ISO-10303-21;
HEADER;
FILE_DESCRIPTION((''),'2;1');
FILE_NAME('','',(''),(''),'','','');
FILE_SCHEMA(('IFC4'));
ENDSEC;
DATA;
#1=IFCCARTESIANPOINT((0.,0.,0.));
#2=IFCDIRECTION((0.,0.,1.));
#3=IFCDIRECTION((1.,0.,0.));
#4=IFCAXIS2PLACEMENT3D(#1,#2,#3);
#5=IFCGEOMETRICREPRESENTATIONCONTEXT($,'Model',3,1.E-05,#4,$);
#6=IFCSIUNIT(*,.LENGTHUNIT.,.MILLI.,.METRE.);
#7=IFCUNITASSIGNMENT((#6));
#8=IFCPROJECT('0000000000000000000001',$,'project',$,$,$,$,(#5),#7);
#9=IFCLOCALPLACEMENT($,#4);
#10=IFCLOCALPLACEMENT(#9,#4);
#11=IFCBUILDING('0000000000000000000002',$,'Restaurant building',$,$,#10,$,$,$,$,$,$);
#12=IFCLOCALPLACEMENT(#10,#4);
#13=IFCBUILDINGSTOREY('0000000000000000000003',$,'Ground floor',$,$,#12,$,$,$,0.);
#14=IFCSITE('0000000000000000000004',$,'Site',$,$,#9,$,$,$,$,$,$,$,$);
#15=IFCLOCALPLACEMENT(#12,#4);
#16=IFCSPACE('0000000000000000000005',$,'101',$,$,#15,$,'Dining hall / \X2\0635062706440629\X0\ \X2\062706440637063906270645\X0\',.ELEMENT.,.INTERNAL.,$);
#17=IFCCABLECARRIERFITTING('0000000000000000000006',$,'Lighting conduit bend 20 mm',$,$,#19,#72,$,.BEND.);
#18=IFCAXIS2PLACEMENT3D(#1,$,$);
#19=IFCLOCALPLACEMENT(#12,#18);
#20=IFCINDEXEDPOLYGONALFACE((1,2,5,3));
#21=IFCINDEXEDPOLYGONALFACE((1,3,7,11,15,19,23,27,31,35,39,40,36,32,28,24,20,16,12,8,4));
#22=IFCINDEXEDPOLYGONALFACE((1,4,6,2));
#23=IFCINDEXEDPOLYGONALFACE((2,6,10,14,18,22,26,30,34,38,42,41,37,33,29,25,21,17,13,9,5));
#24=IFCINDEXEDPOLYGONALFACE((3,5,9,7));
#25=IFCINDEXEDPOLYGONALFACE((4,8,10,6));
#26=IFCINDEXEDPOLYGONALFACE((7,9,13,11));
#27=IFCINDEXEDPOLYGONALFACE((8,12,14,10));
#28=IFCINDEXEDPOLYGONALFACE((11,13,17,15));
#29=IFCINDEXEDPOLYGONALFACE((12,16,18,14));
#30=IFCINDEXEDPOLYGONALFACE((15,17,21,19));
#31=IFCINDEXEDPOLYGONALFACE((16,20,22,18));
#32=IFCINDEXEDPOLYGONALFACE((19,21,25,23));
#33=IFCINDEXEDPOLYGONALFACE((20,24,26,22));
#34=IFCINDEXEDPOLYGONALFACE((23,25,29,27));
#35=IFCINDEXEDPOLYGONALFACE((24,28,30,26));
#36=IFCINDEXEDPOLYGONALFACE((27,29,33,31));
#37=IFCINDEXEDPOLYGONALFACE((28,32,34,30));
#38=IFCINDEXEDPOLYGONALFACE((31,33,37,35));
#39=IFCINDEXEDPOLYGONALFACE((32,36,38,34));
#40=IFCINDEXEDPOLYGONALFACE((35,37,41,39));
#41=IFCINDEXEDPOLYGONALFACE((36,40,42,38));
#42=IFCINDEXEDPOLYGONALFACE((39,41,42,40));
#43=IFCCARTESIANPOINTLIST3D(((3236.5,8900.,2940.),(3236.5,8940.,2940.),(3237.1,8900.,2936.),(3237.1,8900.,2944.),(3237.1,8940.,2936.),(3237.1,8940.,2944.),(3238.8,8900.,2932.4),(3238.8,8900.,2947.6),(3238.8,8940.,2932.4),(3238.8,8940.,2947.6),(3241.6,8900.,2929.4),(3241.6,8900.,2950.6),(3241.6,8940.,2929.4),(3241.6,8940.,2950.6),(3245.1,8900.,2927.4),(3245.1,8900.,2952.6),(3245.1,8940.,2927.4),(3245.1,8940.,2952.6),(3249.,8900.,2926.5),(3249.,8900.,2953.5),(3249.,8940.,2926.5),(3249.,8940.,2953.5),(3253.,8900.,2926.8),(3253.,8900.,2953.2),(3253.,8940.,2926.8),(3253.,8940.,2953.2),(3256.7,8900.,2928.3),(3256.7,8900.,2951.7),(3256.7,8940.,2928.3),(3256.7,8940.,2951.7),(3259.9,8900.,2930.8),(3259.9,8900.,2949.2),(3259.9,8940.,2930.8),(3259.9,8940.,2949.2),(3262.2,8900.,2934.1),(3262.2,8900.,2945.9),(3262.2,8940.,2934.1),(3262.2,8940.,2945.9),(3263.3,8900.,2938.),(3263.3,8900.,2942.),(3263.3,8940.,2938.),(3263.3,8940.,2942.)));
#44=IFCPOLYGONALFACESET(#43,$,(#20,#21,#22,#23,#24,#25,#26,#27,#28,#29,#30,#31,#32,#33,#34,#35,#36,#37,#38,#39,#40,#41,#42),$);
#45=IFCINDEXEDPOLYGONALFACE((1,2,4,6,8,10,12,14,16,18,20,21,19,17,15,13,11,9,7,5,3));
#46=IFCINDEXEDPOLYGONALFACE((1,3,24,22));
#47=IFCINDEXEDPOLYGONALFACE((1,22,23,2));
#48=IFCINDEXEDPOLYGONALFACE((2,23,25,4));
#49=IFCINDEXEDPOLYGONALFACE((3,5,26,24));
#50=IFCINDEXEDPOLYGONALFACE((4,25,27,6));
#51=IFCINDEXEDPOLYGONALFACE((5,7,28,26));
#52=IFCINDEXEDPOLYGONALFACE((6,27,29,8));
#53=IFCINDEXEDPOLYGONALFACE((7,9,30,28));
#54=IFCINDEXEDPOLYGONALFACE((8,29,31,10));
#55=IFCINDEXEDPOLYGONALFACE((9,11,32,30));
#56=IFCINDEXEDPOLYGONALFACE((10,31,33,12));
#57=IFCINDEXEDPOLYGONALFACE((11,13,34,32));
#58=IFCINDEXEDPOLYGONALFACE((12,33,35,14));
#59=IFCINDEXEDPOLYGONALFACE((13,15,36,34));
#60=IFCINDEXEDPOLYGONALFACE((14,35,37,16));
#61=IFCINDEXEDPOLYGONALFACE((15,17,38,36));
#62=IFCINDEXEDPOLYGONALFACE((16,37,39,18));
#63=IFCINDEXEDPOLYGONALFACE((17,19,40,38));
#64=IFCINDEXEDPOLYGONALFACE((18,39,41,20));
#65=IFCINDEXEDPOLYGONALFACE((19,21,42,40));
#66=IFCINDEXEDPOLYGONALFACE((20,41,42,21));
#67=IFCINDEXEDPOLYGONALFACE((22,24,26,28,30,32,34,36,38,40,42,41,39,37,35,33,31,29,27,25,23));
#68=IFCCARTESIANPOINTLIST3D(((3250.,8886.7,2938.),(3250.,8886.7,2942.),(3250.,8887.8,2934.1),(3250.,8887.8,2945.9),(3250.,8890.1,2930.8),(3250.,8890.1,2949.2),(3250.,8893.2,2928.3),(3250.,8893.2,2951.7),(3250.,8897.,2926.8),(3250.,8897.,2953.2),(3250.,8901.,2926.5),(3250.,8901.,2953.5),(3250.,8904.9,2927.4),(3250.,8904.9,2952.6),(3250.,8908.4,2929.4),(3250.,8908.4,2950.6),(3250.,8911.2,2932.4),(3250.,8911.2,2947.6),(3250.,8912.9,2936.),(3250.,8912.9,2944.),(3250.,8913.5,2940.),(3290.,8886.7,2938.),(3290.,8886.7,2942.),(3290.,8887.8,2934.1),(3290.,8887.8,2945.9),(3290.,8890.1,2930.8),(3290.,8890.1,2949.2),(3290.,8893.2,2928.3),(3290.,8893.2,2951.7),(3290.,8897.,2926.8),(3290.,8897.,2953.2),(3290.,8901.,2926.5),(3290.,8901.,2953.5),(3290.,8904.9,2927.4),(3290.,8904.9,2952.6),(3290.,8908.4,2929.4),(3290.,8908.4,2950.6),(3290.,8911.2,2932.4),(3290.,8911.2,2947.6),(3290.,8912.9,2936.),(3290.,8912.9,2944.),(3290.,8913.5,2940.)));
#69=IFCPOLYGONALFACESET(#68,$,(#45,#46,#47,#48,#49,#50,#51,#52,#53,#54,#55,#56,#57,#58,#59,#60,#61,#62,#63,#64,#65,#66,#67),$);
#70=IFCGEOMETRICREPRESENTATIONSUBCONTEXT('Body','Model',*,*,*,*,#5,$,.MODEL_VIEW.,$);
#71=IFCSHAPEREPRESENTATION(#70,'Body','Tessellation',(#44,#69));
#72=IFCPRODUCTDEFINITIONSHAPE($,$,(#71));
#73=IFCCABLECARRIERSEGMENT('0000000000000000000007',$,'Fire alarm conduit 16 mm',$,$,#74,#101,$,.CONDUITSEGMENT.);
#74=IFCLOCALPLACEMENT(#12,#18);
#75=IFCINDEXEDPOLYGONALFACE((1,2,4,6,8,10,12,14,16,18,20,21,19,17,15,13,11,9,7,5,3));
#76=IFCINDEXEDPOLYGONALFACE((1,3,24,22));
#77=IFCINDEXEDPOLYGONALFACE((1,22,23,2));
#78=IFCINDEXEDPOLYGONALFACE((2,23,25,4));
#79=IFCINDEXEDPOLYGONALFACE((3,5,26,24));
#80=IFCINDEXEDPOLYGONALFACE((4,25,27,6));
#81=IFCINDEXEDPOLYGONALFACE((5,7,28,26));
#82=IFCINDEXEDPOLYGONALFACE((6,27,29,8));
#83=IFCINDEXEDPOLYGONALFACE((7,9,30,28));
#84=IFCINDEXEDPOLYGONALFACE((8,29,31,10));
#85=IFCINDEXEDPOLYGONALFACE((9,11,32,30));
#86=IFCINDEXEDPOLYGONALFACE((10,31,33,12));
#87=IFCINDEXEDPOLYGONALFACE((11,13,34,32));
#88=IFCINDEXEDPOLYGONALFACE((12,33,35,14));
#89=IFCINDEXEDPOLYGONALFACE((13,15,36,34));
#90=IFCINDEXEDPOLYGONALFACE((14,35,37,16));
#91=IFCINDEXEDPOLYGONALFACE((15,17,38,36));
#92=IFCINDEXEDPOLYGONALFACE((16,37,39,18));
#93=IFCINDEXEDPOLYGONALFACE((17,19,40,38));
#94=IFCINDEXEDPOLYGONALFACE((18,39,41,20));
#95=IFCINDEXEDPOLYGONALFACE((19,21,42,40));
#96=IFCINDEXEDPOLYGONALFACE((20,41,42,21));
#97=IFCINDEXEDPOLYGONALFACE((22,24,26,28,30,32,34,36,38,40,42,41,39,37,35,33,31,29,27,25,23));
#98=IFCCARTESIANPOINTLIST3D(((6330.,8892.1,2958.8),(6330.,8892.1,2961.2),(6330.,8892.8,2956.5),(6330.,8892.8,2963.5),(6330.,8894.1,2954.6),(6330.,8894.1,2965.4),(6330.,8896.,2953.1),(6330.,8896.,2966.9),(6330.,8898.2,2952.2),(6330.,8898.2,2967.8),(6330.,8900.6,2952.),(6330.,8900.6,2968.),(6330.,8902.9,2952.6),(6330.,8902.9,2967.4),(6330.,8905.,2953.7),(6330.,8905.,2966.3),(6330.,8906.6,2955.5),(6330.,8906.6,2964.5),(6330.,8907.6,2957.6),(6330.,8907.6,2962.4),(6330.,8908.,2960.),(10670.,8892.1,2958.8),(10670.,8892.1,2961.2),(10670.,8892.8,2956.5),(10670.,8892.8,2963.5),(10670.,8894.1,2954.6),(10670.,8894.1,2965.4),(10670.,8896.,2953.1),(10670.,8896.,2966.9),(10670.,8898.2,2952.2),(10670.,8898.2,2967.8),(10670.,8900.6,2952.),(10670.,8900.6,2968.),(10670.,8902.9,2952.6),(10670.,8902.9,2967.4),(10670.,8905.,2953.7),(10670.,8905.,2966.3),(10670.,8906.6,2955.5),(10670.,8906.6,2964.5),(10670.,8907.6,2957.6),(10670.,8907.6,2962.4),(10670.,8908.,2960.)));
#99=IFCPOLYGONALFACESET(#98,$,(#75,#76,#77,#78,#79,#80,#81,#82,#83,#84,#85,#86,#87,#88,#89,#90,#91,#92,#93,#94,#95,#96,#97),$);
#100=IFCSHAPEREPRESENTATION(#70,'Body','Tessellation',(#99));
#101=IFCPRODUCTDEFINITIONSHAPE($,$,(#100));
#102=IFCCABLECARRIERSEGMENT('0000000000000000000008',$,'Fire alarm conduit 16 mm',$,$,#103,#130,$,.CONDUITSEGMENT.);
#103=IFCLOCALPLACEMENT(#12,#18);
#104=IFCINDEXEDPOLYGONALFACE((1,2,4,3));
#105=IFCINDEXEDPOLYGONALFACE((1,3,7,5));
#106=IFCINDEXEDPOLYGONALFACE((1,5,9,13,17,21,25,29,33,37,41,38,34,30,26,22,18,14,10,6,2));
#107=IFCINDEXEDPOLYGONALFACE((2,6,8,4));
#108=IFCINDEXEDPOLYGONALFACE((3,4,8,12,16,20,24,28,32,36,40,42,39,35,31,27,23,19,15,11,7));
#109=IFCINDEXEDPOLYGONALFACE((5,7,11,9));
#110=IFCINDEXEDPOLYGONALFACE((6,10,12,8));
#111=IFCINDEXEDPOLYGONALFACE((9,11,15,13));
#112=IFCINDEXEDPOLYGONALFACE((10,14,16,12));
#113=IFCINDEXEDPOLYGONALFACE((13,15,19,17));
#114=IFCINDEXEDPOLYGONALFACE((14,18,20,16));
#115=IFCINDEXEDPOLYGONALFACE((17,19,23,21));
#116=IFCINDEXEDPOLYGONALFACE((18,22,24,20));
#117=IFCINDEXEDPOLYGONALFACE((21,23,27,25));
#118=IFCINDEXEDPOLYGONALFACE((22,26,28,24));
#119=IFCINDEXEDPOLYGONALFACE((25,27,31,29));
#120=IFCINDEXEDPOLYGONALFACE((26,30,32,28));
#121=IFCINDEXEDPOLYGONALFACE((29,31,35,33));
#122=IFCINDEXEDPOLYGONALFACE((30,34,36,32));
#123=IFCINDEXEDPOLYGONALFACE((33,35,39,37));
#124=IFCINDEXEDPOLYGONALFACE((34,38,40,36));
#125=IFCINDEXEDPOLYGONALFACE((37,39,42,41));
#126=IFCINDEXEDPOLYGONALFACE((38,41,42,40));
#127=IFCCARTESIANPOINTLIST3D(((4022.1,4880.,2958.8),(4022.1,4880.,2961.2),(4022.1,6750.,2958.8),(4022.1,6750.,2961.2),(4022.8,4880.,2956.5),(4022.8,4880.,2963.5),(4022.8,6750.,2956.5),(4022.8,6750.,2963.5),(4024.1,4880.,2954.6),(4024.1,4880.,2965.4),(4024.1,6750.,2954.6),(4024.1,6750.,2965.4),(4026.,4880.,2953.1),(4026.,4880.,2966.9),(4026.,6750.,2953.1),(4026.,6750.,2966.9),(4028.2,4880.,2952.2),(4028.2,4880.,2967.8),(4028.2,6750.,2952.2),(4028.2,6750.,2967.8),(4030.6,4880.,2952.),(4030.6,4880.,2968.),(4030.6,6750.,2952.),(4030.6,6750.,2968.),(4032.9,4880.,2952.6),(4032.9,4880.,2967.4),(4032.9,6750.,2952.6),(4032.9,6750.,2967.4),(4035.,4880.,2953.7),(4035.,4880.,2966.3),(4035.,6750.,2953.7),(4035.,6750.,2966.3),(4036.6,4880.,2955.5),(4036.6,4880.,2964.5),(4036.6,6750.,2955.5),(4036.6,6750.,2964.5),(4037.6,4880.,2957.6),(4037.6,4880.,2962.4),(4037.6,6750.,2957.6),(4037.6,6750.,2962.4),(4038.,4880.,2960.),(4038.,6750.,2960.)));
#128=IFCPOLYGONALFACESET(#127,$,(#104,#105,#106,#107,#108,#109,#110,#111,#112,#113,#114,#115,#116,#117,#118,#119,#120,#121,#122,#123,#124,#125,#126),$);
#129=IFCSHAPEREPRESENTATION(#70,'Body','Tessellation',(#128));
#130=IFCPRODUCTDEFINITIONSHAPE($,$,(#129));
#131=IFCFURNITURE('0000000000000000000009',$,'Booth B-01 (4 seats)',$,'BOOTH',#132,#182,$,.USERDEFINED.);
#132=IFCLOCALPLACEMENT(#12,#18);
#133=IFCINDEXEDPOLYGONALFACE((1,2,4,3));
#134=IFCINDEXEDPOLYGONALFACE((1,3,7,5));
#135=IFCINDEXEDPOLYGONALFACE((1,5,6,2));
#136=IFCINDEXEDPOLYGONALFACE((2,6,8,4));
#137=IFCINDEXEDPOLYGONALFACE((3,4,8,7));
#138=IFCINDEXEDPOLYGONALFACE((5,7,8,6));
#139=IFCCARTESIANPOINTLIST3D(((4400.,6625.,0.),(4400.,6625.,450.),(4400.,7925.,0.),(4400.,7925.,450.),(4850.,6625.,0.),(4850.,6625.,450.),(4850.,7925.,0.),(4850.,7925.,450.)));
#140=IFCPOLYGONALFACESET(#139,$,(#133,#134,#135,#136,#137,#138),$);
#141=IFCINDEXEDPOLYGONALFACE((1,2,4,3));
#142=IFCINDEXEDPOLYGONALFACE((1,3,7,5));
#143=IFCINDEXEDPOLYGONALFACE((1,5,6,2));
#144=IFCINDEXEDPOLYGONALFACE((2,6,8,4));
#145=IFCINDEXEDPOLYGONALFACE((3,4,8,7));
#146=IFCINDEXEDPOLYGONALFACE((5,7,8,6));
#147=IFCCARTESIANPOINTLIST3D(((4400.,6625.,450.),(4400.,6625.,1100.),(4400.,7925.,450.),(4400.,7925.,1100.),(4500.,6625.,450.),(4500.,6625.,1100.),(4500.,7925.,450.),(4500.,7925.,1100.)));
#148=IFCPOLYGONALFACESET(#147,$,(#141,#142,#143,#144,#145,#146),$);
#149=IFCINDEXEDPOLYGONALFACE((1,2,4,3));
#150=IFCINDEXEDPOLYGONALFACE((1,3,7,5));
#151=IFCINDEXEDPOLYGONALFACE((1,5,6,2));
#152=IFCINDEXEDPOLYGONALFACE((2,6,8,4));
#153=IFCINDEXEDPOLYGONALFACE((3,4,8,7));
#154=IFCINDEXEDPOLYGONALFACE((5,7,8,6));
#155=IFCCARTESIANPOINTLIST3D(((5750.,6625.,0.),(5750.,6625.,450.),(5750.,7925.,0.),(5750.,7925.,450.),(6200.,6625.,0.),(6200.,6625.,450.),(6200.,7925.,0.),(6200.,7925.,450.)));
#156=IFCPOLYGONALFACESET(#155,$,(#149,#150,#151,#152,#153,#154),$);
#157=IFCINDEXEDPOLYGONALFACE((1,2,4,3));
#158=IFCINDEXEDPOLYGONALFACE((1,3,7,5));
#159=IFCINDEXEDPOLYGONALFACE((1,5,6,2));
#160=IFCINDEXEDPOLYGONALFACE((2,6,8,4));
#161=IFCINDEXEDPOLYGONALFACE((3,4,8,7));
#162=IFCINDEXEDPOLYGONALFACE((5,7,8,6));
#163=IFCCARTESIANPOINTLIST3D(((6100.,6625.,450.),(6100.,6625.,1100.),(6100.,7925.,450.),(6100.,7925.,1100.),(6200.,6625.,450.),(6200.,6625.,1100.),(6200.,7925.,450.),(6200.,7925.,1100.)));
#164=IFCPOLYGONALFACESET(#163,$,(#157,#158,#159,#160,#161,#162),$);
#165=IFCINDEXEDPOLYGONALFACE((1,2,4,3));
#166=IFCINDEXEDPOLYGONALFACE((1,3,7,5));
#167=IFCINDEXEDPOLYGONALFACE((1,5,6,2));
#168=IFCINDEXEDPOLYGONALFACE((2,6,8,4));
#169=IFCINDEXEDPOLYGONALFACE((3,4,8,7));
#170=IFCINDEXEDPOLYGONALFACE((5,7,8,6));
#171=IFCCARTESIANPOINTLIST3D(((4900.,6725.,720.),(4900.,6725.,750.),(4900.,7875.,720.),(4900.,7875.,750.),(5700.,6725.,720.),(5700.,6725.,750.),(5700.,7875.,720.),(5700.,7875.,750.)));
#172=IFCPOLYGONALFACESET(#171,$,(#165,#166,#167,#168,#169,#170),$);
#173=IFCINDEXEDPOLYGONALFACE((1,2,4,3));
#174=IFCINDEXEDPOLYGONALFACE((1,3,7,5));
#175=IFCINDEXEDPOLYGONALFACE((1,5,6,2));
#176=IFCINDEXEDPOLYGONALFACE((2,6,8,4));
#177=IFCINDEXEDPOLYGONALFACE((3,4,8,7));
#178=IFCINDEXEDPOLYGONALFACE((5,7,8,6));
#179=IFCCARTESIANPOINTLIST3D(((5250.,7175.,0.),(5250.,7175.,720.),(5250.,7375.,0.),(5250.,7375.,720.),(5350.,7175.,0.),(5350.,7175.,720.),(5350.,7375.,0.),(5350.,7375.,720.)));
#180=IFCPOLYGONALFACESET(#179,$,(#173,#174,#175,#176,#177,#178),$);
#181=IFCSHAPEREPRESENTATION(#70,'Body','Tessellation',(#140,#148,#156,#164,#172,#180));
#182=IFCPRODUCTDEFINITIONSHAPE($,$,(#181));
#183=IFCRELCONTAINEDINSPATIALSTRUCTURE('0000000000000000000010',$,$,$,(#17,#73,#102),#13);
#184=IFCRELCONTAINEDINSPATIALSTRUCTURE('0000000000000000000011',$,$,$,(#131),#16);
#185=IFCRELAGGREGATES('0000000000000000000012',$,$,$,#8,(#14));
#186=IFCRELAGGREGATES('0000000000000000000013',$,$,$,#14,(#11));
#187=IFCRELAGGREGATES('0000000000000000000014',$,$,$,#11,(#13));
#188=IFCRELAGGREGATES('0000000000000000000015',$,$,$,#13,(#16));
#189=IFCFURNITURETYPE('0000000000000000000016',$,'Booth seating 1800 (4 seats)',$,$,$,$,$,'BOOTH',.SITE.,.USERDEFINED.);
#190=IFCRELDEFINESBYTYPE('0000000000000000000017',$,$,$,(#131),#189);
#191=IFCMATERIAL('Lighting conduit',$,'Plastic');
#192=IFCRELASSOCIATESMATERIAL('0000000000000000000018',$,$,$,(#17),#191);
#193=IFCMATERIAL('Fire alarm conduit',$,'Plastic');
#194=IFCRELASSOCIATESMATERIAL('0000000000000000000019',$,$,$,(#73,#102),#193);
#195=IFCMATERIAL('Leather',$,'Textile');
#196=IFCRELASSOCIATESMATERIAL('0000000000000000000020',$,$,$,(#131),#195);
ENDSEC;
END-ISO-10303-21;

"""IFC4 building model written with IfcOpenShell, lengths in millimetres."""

from ifc_helpers import new_model, si_unit, frame, origin, origin_with_axes, origin_2d, place, context, subcontext, project, spatial, rectangle, circle, extrude, source, transform, mapped, material, type_object, type_shapes, element, save


model = new_model("IFC4")

# Units and contexts
model_context = context("Model", 3, precision=1e-05, world=origin_with_axes())
body_context = subcontext(model_context, "Body", "Model", "MODEL_VIEW")
ifc_project = project(units=[si_unit("LENGTHUNIT", "METRE", prefix="MILLI")], contexts=[model_context])

# Site, building, storey
site_placement = place(None, origin_with_axes())
site = spatial("IfcSite", under=ifc_project, at=site_placement, Name="Site")
building_placement = place(site_placement, origin_with_axes())
building = spatial("IfcBuilding", under=site, at=building_placement, Name="Restaurant building")
storey_placement = place(building_placement, origin_with_axes())
storey = spatial("IfcBuildingStorey", under=building, at=storey_placement, Name="Ground floor", Elevation=0.0)

# Shared definitions
space_1_placement = place(storey_placement, origin_with_axes())
space_1 = spatial("IfcSpace", under=storey, at=space_1_placement, Name="101", LongName="Dining hall / صالة الطعام", CompositionType="ELEMENT", PredefinedType="INTERNAL")

# Shared definitions
ifc_material_1 = material(Name="Lighting conduit", Category="Plastic")

# Cable carrier fitting
cable_carrier_fitting_1_placement = place(storey_placement, frame((3250.0, 8900.0, 2940.0)))
element("IfcCableCarrierFitting", 1, at=cable_carrier_fitting_1_placement, inside=storey, material=ifc_material_1, Name="Lighting conduit bend 20 mm", PredefinedType="BEND", context=body_context, shape_type="SweptSolid", body=[
    extrude(circle(Radius=13.5, at=origin_2d()), frame((0.0, 0.0, 0.0), z_axis=(0.0, 1.0, 0.0), x_axis=(-1.0, 0.0, 0.0)), (0.0, 0.0, 1.0), 40.0),
    extrude(circle(Radius=13.5, at=origin_2d()), frame((0.0, 0.0, 0.0), z_axis=(1.0, 0.0, 0.0), x_axis=(0.0, 1.0, 0.0)), (0.0, 0.0, 1.0), 40.0),
])

# Cable carrier segments
ifc_material_2 = material(Name="Fire alarm conduit", Category="Plastic")
cable_carrier_segment_1_placement = place(storey_placement, frame((6330.0, 8900.0, 2960.0)))
element("IfcCableCarrierSegment", 2, at=cable_carrier_segment_1_placement, inside=storey, material=ifc_material_2, Name="Fire alarm conduit 16 mm", PredefinedType="CONDUITSEGMENT", context=body_context, shape_type="SweptSolid", body=[
    extrude(circle(Radius=8.0, at=origin_2d()), frame((0.0, 0.0, 0.0), z_axis=(1.0, 0.0, 0.0), x_axis=(0.0, 1.0, 0.0)), (0.0, 0.0, 1.0), 4340.0),
])
cable_carrier_segment_2_placement = place(storey_placement, frame((4030.0, 6750.0, 2960.0)))
element("IfcCableCarrierSegment", 3, at=cable_carrier_segment_2_placement, inside=storey, material=ifc_material_2, Name="Fire alarm conduit 16 mm", PredefinedType="CONDUITSEGMENT", context=body_context, shape_type="SweptSolid", body=[
    extrude(circle(Radius=8.0, at=origin_2d()), frame((0.0, 0.0, 0.0), z_axis=(0.0, -1.0, 0.0), x_axis=(1.0, 0.0, 0.0)), (0.0, 0.0, 1.0), 1870.0),
])

# Furniture
ifc_material_3 = material(Name="Leather", Category="Textile")
furniture_type_1 = type_object("IfcFurnitureType", Name="Booth seating 1800 (4 seats)", ElementType="BOOTH", AssemblyPlace="SITE", PredefinedType="USERDEFINED")
shared_shape_1 = source(origin(), body_context, "Body", "SweptSolid", [
    extrude(rectangle(XDim=450.0, YDim=1300.0, at=origin_2d()), frame((-675.0, -650.0, 0.0)), (0.0, 0.0, 1.0), 450.0),
    extrude(rectangle(XDim=100.0, YDim=1300.0, at=origin_2d()), frame((-850.0, -650.0, 450.0)), (0.0, 0.0, 1.0), 650.0),
    extrude(rectangle(XDim=450.0, YDim=1300.0, at=origin_2d()), frame((675.0, -650.0, 0.0)), (0.0, 0.0, 1.0), 450.0),
    extrude(rectangle(XDim=100.0, YDim=1300.0, at=origin_2d()), frame((850.0, -650.0, 450.0)), (0.0, 0.0, 1.0), 650.0),
    extrude(rectangle(XDim=800.0, YDim=1150.0, at=origin_2d()), frame((0.0, -625.0, 720.0)), (0.0, 0.0, 1.0), 30.0),
    extrude(rectangle(XDim=100.0, YDim=200.0, at=origin_2d()), frame((0.0, -650.0, 0.0)), (0.0, 0.0, 1.0), 720.0),
])
type_shapes(furniture_type_1, [shared_shape_1])
furniture_1_placement = place(storey_placement, frame((5300.0, 7925.0, 0.0)))
element("IfcFurniture", 4, at=furniture_1_placement, inside=space_1, type_object=furniture_type_1, material=ifc_material_3, Name="Booth B-01 (4 seats)", ObjectType="BOOTH", PredefinedType="USERDEFINED", context=body_context, shape_type="MappedRepresentation", body=[
    mapped(shared_shape_1, transform((0.0, 0.0, 0.0))),
])

save(model, "model.ifc")
